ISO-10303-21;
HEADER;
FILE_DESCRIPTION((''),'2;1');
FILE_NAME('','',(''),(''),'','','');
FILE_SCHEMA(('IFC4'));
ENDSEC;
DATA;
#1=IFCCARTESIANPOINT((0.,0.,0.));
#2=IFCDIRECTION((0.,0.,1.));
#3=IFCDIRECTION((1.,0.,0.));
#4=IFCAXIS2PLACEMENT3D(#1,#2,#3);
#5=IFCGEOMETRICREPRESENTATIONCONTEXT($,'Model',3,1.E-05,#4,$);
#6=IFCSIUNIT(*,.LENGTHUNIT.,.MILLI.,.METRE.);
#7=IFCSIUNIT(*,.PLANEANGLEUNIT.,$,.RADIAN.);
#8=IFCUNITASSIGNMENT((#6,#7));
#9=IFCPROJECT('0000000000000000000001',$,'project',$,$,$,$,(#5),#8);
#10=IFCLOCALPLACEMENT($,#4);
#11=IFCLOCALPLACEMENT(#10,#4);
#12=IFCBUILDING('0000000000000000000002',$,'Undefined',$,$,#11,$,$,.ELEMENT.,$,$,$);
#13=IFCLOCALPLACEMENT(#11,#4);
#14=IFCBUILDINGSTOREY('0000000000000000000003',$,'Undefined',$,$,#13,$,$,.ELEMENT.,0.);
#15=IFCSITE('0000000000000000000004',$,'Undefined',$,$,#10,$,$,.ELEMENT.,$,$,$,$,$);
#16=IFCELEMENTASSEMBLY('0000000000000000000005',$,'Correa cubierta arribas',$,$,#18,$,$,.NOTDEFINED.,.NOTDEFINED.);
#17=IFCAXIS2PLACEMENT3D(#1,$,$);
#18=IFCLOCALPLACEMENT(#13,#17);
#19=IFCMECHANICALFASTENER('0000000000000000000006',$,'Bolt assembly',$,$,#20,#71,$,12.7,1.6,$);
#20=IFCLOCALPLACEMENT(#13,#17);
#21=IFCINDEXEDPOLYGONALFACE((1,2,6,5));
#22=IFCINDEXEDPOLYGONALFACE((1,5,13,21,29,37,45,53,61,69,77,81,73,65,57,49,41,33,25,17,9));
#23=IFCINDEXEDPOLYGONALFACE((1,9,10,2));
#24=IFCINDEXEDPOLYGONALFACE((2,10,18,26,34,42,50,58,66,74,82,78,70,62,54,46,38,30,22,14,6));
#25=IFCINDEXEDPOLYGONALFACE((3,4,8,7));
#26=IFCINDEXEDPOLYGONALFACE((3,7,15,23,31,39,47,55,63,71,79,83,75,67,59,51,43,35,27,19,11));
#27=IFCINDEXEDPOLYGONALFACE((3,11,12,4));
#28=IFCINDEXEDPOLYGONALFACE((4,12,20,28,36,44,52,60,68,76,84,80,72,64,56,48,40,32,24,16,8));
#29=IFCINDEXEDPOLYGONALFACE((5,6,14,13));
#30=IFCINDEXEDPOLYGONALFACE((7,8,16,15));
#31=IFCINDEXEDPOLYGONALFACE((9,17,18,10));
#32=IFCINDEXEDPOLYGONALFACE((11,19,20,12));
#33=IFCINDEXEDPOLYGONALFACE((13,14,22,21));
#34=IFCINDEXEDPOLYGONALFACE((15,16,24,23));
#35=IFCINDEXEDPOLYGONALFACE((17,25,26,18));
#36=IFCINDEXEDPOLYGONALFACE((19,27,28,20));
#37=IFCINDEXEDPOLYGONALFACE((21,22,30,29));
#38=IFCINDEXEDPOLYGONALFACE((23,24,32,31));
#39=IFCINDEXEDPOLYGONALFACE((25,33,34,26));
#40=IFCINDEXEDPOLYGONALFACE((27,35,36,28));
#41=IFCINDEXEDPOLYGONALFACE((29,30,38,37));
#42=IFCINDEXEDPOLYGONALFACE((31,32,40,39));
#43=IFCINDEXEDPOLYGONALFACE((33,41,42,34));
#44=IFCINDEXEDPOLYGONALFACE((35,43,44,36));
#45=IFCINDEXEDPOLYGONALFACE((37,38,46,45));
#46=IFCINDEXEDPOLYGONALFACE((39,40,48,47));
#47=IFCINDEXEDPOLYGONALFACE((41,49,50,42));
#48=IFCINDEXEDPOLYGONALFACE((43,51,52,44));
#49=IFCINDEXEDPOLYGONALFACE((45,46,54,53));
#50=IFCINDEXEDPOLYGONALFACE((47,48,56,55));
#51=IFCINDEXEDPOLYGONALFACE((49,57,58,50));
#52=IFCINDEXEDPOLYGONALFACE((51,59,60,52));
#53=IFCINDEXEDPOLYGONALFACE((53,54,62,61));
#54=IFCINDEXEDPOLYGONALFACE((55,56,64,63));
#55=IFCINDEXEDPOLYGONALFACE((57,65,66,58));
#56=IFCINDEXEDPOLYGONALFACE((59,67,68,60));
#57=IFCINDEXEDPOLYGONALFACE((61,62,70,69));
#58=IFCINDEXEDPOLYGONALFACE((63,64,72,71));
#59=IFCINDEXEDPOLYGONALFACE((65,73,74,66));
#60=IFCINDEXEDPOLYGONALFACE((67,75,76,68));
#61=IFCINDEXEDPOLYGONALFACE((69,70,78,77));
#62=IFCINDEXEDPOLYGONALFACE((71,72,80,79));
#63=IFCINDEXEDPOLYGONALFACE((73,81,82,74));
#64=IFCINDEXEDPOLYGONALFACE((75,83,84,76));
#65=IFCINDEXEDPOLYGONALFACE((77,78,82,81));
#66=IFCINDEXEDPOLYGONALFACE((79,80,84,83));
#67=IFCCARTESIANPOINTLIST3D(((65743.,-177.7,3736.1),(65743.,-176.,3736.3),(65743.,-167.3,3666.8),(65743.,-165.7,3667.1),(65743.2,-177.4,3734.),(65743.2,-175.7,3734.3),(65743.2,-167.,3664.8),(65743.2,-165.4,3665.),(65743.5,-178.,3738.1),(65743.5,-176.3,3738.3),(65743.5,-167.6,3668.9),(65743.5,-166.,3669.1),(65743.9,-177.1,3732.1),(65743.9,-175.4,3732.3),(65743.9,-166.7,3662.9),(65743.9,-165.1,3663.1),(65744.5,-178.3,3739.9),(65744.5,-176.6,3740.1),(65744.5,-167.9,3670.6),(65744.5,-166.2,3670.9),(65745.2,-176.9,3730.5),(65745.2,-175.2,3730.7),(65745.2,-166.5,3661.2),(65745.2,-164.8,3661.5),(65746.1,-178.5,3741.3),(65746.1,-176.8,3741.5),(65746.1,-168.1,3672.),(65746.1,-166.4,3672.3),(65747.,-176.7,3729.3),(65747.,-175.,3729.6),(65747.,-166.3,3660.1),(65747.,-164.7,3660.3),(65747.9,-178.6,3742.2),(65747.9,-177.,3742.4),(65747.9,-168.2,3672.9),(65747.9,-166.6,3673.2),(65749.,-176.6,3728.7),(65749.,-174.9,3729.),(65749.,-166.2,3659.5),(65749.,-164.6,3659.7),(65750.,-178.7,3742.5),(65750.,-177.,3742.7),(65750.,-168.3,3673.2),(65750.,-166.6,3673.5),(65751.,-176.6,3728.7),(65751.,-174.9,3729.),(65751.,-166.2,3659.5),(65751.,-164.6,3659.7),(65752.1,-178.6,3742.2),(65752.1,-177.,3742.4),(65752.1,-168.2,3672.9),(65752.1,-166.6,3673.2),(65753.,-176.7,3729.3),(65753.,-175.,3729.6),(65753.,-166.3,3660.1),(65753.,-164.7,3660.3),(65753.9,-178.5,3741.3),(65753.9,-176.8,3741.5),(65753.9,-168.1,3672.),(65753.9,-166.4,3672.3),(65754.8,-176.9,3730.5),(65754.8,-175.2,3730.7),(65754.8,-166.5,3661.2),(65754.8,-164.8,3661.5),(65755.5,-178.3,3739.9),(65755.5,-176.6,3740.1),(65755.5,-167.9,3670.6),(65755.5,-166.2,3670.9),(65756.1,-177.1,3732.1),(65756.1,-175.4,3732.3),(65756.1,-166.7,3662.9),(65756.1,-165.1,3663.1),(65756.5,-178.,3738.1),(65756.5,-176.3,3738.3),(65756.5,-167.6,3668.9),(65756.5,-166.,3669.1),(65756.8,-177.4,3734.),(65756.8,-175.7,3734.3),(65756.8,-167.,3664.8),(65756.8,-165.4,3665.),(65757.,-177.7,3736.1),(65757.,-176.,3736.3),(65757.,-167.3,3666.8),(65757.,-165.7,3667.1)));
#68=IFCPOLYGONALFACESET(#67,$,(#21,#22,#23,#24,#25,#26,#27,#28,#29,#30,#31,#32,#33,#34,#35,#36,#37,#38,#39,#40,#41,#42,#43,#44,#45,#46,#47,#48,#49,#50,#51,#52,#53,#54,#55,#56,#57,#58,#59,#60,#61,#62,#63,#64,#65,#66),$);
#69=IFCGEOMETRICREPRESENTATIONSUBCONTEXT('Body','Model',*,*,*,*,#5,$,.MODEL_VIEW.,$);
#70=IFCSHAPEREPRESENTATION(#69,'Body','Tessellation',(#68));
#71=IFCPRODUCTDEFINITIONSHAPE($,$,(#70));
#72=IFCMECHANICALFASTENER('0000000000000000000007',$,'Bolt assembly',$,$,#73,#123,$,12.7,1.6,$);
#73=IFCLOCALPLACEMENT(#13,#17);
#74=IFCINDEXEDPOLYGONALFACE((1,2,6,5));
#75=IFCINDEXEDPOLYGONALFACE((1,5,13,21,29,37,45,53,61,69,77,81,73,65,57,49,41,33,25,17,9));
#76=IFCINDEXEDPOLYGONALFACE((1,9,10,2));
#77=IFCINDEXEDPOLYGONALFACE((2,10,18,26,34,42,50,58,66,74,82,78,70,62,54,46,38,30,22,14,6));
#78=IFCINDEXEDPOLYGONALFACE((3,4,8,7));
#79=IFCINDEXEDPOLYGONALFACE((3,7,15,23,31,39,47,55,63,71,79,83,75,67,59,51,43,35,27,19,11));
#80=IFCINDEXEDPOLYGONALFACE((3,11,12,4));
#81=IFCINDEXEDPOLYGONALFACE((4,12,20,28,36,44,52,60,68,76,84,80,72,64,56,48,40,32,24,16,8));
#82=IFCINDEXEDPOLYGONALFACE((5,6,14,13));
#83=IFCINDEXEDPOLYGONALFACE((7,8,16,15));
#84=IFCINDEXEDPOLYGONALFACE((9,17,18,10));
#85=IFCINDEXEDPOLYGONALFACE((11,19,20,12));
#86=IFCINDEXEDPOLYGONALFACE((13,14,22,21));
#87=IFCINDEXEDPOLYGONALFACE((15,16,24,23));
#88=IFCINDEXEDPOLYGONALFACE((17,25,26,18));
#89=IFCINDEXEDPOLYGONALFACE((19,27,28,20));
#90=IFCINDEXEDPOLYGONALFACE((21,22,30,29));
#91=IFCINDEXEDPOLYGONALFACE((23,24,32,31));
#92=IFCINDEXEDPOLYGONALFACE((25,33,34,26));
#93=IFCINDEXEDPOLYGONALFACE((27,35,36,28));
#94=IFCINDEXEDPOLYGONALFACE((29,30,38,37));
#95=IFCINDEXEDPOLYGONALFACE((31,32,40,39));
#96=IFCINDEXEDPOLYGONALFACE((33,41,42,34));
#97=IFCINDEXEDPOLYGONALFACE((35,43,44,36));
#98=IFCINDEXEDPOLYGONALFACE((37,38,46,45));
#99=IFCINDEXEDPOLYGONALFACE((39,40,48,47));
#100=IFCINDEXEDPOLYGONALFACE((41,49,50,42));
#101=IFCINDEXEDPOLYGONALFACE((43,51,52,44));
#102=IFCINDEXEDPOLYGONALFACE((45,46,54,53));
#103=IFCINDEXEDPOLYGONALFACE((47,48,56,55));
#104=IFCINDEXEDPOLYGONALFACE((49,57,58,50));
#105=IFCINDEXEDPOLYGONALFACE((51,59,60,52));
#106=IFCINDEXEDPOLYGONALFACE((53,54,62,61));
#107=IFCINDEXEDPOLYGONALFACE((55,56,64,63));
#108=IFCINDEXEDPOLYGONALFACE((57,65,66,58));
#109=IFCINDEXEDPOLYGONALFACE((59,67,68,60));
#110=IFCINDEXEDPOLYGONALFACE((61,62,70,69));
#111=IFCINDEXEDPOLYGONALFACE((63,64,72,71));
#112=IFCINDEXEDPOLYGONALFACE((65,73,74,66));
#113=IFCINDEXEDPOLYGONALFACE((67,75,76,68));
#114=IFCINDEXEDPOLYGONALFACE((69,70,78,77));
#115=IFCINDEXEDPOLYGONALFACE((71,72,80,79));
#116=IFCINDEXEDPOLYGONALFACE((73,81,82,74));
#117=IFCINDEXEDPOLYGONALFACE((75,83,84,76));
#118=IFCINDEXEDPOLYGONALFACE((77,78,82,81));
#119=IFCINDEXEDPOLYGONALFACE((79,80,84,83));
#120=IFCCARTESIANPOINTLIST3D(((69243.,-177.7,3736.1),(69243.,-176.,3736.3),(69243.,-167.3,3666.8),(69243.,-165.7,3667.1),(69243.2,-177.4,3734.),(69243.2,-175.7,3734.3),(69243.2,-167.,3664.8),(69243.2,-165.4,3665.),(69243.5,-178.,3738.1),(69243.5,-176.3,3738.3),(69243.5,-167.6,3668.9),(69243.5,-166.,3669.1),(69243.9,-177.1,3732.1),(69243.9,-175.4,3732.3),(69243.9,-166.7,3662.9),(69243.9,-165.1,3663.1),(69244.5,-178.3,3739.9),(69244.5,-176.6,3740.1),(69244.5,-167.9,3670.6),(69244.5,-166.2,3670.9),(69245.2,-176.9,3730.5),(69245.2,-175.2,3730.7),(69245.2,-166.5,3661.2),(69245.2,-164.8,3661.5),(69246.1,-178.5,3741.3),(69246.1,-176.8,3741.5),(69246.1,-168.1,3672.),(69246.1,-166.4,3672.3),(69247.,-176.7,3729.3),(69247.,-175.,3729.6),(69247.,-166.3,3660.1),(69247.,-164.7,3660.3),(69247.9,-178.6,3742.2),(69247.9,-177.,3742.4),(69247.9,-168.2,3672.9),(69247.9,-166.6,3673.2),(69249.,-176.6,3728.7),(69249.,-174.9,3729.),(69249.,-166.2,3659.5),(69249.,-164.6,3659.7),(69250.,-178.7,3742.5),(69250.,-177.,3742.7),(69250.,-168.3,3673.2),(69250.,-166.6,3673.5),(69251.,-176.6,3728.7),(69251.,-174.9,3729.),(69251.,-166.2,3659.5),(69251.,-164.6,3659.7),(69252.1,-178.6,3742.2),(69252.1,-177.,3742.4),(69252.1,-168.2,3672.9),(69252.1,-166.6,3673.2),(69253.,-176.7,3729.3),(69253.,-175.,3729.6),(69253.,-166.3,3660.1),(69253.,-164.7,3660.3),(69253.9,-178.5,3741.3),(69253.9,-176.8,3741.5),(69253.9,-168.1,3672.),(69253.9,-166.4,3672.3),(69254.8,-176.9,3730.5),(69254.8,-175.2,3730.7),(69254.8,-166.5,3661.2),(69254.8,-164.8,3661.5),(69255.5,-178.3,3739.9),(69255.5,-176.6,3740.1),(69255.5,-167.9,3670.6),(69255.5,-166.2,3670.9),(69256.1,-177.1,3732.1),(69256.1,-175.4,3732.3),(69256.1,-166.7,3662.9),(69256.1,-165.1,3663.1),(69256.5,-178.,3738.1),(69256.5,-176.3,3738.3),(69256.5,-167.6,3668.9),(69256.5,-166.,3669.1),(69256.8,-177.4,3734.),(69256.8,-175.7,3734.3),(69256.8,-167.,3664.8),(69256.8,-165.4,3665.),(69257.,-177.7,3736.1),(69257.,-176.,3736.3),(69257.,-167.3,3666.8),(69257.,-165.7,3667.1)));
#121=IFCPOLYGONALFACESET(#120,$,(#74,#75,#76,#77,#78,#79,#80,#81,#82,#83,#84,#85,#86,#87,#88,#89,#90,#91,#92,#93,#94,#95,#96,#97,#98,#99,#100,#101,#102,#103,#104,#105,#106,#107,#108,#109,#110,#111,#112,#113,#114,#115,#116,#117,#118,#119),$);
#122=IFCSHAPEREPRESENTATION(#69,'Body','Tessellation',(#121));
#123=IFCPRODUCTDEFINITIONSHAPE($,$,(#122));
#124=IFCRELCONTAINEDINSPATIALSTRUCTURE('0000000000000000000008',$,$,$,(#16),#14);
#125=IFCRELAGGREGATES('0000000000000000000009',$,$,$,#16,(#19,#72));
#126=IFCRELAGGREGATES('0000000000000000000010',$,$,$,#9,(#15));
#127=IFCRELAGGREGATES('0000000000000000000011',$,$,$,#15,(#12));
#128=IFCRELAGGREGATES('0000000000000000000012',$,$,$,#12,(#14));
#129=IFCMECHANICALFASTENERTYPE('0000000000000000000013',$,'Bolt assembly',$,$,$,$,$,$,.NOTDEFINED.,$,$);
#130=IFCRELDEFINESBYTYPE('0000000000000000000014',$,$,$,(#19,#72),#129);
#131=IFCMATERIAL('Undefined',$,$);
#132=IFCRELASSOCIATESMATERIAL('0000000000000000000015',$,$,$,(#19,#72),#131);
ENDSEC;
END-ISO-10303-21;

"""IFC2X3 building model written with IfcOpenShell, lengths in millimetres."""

from ifc_helpers import new_model, si_unit, frame, origin_with_axes, origin_2d_with_axis, place, context, subcontext, project, spatial, circle, extrude, source, transform, mapped, material, type_object, element, aggregate, save


model = new_model("IFC2X3")

# Units and contexts
model_context = context("Model", 3, precision=1e-05, world=origin_with_axes())
body_context = subcontext(model_context, "Body", "Model", "MODEL_VIEW")
ifc_project = project(units=[si_unit("LENGTHUNIT", "METRE", prefix="MILLI"), si_unit("PLANEANGLEUNIT", "RADIAN")], contexts=[model_context])

# Site, building, storey
site_placement = place(None, origin_with_axes())
site = spatial("IfcSite", under=ifc_project, at=site_placement, Name="Undefined", CompositionType="ELEMENT")
building_placement = place(site_placement, origin_with_axes())
building = spatial("IfcBuilding", under=site, at=building_placement, Name="Undefined", CompositionType="ELEMENT")
storey_placement = place(building_placement, origin_with_axes())
storey = spatial("IfcBuildingStorey", under=building, at=storey_placement, Name="Undefined", CompositionType="ELEMENT", Elevation=0.0)

# Shared definitions
ifc_material_1 = material(Name="Undefined")
mechanical_fastener_type = type_object("IfcMechanicalFastenerType", Name="Bolt assembly")

# Element assembly, mechanical fasteners
shared_shape_1 = source(origin_with_axes(), body_context, "Body", "SweptSolid", [
    extrude(circle(Radius=7.0, at=origin_2d_with_axis()), frame((0.0, 6.4, 0.0), z_axis=(0.0, 1.0, 0.0), x_axis=(1.0, 0.0, 0.0)), (0.0, 0.0, 1.0), 1.7),
])
assembly_1_placement = place(storey_placement, origin_with_axes())
assembly_1 = element("IfcElementAssembly", 1, at=assembly_1_placement, inside=storey, Name="Correa cubierta arribas", AssemblyPlace="NOTDEFINED", PredefinedType="NOTDEFINED")
mechanical_fastener_1_placement = place(assembly_1_placement, frame((65750.0, -159.3, 3667.5), z_axis=(1.0, 0.0, 0.0), x_axis=(0.0, -0.148209, 0.988956)))
mechanical_fastener_1 = element("IfcMechanicalFastener", 2, at=mechanical_fastener_1_placement, type_object=mechanical_fastener_type, material=ifc_material_1, Name="Bolt assembly", NominalDiameter=12.7, NominalLength=1.6, context=body_context, shape_type="MappedRepresentation", body=[
    mapped(shared_shape_1, transform((0.0, 0.0, 0.0))),
    mapped(shared_shape_1, transform((70.0, 0.0, 0.0))),
])
mechanical_fastener_2_placement = place(assembly_1_placement, frame((69250.0, -159.3, 3667.5), z_axis=(1.0, 0.0, 0.0), x_axis=(0.0, -0.148209, 0.988956)))
mechanical_fastener_2 = element("IfcMechanicalFastener", 3, at=mechanical_fastener_2_placement, type_object=mechanical_fastener_type, material=ifc_material_1, Name="Bolt assembly", NominalDiameter=12.7, NominalLength=1.6, context=body_context, shape_type="MappedRepresentation", body=[
    mapped(shared_shape_1, transform((0.0, 0.0, 0.0))),
    mapped(shared_shape_1, transform((70.0, 0.0, 0.0))),
])
aggregate(assembly_1, [mechanical_fastener_1, mechanical_fastener_2])

save(model, "model.ifc")
